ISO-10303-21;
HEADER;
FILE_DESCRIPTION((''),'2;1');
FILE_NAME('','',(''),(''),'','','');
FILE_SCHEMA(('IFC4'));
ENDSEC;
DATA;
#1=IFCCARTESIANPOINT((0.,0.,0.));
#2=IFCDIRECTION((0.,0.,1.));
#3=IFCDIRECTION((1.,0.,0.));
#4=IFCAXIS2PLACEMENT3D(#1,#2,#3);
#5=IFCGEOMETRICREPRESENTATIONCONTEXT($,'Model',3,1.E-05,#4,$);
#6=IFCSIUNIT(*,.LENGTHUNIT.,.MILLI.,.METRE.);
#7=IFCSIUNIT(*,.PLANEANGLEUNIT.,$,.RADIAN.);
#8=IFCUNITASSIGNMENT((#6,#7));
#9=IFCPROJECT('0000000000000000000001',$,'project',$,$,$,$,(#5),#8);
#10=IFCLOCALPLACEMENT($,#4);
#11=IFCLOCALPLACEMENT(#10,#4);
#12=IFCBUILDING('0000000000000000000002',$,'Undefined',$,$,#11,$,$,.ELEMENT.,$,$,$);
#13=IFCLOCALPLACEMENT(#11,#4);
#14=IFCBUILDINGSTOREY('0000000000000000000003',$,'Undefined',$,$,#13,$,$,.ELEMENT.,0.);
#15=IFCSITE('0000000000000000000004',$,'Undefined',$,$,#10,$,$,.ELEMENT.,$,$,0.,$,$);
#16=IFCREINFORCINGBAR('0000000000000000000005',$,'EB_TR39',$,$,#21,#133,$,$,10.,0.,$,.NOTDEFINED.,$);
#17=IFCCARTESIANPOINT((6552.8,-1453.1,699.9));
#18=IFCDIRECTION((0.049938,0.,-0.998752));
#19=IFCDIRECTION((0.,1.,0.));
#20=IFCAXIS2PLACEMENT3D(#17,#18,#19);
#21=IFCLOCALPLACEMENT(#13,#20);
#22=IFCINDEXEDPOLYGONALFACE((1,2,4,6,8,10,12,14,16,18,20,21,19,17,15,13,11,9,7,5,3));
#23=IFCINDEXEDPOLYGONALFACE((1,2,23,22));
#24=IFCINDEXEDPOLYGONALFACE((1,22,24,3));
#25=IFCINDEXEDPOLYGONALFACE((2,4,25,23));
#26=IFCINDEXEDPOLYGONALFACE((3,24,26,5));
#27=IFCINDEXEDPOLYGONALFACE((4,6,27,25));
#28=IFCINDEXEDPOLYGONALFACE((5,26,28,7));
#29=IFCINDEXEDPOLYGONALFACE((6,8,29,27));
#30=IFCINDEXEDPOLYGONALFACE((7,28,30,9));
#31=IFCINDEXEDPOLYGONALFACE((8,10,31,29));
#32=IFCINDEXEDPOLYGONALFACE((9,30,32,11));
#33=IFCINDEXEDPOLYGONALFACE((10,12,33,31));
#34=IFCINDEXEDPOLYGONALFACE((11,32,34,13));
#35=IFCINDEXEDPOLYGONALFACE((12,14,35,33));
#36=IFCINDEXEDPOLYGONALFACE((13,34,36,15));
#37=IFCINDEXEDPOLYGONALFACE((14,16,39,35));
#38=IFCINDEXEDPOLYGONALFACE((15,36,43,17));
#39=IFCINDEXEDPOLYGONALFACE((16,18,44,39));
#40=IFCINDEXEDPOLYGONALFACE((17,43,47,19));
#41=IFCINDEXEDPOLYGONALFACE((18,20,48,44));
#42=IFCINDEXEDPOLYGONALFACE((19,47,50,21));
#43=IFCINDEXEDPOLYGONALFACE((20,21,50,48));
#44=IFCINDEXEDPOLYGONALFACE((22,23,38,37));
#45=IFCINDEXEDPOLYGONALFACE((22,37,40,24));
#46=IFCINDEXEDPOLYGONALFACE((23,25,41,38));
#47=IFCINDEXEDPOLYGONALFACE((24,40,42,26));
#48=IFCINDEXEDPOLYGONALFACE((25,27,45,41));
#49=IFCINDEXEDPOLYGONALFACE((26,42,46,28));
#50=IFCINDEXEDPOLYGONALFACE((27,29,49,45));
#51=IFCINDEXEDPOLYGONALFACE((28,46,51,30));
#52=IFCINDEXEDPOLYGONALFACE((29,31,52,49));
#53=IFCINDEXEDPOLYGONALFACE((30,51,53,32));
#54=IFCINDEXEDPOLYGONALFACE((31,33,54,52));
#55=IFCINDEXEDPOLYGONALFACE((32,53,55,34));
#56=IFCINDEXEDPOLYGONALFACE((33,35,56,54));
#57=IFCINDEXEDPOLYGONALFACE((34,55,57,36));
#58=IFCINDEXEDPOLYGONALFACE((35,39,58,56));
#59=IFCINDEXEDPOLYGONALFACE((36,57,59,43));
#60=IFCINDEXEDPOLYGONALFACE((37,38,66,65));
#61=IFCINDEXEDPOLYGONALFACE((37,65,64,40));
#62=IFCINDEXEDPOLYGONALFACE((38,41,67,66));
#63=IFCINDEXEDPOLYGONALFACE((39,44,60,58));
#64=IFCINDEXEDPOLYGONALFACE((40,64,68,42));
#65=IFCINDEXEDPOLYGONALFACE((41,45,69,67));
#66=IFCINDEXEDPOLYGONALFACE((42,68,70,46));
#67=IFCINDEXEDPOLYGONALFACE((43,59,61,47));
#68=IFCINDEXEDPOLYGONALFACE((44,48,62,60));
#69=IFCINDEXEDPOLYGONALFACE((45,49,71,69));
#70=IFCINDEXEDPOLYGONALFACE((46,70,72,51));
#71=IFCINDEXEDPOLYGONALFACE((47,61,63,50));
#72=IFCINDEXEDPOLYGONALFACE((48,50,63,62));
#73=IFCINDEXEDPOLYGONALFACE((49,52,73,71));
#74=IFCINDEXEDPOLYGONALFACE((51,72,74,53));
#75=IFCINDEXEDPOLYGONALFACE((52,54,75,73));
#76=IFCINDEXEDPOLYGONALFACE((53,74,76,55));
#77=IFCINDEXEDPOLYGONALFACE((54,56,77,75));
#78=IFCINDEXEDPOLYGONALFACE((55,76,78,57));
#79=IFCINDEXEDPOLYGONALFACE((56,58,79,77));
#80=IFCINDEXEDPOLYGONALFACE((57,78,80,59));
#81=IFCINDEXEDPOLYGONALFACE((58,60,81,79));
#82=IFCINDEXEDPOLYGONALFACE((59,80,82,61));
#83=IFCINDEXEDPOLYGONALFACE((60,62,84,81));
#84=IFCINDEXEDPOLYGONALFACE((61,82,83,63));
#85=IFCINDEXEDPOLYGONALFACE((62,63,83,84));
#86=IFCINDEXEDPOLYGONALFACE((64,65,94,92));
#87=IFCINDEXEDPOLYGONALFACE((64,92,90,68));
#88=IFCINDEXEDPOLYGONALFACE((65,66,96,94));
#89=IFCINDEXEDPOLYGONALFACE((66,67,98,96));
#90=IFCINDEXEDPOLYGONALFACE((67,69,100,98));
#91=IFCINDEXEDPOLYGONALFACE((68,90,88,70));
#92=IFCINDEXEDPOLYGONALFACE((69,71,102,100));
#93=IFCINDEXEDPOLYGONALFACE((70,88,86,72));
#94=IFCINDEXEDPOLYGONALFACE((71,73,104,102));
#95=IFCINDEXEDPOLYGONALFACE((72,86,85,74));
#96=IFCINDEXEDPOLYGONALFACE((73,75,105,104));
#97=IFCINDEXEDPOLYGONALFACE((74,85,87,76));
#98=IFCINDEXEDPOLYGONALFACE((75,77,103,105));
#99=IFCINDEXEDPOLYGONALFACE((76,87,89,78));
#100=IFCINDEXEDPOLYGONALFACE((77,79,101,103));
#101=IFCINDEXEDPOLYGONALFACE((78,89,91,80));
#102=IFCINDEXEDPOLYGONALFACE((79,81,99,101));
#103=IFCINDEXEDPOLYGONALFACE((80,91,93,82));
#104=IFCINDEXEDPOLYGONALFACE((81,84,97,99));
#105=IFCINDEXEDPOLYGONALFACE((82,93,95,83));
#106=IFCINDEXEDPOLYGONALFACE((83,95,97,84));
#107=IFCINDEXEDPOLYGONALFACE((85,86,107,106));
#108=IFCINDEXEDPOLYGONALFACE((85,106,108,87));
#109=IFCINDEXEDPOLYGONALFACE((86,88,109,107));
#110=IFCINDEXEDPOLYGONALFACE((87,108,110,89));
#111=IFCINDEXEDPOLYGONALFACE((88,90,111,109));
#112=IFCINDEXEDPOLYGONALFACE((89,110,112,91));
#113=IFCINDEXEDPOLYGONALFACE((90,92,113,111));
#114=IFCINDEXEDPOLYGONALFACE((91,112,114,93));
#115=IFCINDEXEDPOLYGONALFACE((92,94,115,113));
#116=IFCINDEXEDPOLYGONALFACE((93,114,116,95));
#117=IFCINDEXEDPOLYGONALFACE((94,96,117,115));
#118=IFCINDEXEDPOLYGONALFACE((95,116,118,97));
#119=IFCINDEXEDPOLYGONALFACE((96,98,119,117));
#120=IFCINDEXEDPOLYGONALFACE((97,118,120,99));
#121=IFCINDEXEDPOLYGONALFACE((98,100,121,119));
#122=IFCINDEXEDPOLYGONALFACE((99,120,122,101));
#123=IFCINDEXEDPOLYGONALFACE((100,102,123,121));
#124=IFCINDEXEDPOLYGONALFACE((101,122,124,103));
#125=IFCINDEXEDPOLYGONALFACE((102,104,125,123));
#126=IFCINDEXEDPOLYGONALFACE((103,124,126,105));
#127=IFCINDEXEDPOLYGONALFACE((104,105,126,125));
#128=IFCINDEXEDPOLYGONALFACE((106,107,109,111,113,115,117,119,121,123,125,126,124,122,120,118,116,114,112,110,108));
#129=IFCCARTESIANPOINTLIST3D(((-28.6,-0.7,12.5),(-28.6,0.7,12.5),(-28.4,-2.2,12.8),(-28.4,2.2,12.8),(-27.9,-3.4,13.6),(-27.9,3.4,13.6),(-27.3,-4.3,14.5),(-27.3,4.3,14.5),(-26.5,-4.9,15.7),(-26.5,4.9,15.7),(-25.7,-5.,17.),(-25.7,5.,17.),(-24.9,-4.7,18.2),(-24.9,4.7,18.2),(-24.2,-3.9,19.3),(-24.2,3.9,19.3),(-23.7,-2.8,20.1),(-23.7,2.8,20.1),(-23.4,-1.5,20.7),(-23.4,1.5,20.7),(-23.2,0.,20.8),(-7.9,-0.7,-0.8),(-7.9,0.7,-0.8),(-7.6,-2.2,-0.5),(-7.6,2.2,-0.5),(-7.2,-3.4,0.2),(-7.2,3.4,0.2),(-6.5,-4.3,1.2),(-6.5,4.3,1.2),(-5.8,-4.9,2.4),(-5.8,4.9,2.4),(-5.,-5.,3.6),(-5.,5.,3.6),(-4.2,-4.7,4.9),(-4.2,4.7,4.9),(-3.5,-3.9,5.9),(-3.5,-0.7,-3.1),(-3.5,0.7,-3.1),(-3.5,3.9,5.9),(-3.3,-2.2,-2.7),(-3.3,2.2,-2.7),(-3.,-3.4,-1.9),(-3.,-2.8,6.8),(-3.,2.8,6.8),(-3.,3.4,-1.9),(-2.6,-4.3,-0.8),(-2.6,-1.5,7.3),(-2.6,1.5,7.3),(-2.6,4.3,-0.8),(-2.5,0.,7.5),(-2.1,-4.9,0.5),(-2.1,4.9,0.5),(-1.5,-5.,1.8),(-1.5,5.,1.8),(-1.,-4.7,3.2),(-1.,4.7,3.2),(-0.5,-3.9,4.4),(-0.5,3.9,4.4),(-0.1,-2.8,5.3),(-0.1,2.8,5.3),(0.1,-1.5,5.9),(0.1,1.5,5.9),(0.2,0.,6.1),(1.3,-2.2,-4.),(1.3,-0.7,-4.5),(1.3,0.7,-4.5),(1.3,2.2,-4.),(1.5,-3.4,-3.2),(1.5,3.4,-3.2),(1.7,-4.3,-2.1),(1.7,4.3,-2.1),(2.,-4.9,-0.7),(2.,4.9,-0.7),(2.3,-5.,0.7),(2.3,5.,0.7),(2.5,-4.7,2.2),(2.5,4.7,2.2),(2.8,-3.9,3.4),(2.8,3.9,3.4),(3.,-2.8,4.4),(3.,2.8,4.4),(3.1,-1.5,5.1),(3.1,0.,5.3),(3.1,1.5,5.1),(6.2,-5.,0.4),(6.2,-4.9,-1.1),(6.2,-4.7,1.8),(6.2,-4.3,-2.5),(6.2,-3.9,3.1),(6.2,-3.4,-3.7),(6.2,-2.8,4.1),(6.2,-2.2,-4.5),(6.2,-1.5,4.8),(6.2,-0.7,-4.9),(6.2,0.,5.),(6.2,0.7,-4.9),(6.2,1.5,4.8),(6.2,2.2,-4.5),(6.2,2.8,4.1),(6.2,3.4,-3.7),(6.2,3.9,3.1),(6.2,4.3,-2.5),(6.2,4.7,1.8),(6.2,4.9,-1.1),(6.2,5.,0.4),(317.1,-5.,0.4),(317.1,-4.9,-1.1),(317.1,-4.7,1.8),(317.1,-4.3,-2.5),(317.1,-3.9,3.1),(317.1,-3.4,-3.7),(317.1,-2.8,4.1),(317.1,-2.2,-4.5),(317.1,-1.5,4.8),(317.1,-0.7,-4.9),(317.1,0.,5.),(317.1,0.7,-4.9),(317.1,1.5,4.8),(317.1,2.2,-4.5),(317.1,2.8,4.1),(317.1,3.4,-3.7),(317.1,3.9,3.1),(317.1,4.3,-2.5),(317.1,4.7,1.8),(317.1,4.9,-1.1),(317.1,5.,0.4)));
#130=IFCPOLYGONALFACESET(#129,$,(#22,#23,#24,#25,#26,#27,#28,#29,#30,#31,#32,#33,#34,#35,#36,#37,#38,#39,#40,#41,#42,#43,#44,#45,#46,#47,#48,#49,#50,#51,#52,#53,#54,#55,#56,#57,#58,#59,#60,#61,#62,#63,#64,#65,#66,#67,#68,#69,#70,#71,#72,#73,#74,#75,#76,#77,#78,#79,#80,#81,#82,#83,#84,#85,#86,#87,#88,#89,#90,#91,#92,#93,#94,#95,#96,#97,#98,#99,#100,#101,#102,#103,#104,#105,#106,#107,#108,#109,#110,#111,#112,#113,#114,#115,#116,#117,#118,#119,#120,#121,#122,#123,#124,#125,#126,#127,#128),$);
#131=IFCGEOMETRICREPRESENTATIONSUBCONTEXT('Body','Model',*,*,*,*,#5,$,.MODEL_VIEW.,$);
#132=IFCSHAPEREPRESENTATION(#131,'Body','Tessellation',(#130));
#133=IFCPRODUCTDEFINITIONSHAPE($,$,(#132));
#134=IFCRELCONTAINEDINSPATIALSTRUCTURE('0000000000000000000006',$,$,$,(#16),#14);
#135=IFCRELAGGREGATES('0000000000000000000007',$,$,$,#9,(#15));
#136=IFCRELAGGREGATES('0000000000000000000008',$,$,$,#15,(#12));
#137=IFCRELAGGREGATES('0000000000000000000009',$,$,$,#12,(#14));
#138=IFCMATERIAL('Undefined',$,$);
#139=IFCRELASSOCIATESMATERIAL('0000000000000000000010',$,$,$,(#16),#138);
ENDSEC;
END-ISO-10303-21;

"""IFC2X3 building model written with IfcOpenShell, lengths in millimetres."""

from ifc_helpers import new_model, entity, si_unit, frame, origin_with_axes, place, context, subcontext, project, spatial, source, transform, mapped, material, element, save


model = new_model("IFC2X3")

# Units and contexts
model_context = context("Model", 3, precision=1e-05, world=origin_with_axes())
body_context = subcontext(model_context, "Body", "Model", "MODEL_VIEW")
ifc_project = project(units=[si_unit("LENGTHUNIT", "METRE", prefix="MILLI"), si_unit("PLANEANGLEUNIT", "RADIAN")], contexts=[model_context])

# Site, building, storey
site_placement = place(None, origin_with_axes())
site = spatial("IfcSite", under=ifc_project, at=site_placement, Name="Undefined", CompositionType="ELEMENT", RefElevation=0.0)
building_placement = place(site_placement, origin_with_axes())
building = spatial("IfcBuilding", under=site, at=building_placement, Name="Undefined", CompositionType="ELEMENT")
storey_placement = place(building_placement, origin_with_axes())
storey = spatial("IfcBuildingStorey", under=building, at=storey_placement, Name="Undefined", CompositionType="ELEMENT", Elevation=0.0)

# Reinforcing bar
ifc_material_1 = material(Name="Undefined")
shared_shape_1 = source(origin_with_axes(), body_context, "Body", "AdvancedSweptSolid", [
    entity("IfcSweptDiskSolid", entity("IfcCompositeCurve", [entity("IfcCompositeCurveSegment", "CONTINUOUS", True, entity("IfcTrimmedCurve", entity("IfcLine", entity("IfcCartesianPoint", [0.0, 0.0, 0.0]), entity("IfcVector", entity("IfcDirection", [0.841694, 0.0, -0.539955]), 1.0)), [entity("IfcParameterValue", 0.0)], [entity("IfcParameterValue", 24.65374)], True, "PARAMETER")), entity("IfcCompositeCurveSegment", "CONTINUOUS", True, entity("IfcTrimmedCurve", entity("IfcCircle", entity("IfcAxis2Placement3D", entity("IfcCartesianPoint", [32.1, 0.0, 4.4]), entity("IfcDirection", [0.0, -1.0, 0.0]), entity("IfcDirection", [-0.539955, 0.0, -0.841694])), 21.0), [entity("IfcParameterValue", 0.0)], [entity("IfcParameterValue", 0.570383)], True, "PARAMETER")), entity("IfcCompositeCurveSegment", "DISCONTINUOUS", True, entity("IfcTrimmedCurve", entity("IfcLine", entity("IfcCartesianPoint", [32.1, 0.0, -16.6]), entity("IfcVector", entity("IfcDirection", [1.0, 0.0, 0.0]), 1.0)), [entity("IfcParameterValue", 0.0)], [entity("IfcParameterValue", 310.940714)], True, "PARAMETER"))], False), 5.0, None, 0.0, 336.2),
])
reinforcing_bar_1_placement = place(storey_placement, frame((6552.8, -1453.1, 699.9), z_axis=(0.049938, 0.0, -0.998752), x_axis=(0.0, 1.0, 0.0)))
element("IfcReinforcingBar", 1, at=reinforcing_bar_1_placement, inside=storey, material=ifc_material_1, Name="EB_TR39", BarRole="NOTDEFINED", CrossSectionArea=0.0, NominalDiameter=10.0, context=body_context, shape_type="MappedRepresentation", body=[
    mapped(shared_shape_1, transform((-25.9, 0.0, 16.6))),
])

save(model, "model.ifc")
